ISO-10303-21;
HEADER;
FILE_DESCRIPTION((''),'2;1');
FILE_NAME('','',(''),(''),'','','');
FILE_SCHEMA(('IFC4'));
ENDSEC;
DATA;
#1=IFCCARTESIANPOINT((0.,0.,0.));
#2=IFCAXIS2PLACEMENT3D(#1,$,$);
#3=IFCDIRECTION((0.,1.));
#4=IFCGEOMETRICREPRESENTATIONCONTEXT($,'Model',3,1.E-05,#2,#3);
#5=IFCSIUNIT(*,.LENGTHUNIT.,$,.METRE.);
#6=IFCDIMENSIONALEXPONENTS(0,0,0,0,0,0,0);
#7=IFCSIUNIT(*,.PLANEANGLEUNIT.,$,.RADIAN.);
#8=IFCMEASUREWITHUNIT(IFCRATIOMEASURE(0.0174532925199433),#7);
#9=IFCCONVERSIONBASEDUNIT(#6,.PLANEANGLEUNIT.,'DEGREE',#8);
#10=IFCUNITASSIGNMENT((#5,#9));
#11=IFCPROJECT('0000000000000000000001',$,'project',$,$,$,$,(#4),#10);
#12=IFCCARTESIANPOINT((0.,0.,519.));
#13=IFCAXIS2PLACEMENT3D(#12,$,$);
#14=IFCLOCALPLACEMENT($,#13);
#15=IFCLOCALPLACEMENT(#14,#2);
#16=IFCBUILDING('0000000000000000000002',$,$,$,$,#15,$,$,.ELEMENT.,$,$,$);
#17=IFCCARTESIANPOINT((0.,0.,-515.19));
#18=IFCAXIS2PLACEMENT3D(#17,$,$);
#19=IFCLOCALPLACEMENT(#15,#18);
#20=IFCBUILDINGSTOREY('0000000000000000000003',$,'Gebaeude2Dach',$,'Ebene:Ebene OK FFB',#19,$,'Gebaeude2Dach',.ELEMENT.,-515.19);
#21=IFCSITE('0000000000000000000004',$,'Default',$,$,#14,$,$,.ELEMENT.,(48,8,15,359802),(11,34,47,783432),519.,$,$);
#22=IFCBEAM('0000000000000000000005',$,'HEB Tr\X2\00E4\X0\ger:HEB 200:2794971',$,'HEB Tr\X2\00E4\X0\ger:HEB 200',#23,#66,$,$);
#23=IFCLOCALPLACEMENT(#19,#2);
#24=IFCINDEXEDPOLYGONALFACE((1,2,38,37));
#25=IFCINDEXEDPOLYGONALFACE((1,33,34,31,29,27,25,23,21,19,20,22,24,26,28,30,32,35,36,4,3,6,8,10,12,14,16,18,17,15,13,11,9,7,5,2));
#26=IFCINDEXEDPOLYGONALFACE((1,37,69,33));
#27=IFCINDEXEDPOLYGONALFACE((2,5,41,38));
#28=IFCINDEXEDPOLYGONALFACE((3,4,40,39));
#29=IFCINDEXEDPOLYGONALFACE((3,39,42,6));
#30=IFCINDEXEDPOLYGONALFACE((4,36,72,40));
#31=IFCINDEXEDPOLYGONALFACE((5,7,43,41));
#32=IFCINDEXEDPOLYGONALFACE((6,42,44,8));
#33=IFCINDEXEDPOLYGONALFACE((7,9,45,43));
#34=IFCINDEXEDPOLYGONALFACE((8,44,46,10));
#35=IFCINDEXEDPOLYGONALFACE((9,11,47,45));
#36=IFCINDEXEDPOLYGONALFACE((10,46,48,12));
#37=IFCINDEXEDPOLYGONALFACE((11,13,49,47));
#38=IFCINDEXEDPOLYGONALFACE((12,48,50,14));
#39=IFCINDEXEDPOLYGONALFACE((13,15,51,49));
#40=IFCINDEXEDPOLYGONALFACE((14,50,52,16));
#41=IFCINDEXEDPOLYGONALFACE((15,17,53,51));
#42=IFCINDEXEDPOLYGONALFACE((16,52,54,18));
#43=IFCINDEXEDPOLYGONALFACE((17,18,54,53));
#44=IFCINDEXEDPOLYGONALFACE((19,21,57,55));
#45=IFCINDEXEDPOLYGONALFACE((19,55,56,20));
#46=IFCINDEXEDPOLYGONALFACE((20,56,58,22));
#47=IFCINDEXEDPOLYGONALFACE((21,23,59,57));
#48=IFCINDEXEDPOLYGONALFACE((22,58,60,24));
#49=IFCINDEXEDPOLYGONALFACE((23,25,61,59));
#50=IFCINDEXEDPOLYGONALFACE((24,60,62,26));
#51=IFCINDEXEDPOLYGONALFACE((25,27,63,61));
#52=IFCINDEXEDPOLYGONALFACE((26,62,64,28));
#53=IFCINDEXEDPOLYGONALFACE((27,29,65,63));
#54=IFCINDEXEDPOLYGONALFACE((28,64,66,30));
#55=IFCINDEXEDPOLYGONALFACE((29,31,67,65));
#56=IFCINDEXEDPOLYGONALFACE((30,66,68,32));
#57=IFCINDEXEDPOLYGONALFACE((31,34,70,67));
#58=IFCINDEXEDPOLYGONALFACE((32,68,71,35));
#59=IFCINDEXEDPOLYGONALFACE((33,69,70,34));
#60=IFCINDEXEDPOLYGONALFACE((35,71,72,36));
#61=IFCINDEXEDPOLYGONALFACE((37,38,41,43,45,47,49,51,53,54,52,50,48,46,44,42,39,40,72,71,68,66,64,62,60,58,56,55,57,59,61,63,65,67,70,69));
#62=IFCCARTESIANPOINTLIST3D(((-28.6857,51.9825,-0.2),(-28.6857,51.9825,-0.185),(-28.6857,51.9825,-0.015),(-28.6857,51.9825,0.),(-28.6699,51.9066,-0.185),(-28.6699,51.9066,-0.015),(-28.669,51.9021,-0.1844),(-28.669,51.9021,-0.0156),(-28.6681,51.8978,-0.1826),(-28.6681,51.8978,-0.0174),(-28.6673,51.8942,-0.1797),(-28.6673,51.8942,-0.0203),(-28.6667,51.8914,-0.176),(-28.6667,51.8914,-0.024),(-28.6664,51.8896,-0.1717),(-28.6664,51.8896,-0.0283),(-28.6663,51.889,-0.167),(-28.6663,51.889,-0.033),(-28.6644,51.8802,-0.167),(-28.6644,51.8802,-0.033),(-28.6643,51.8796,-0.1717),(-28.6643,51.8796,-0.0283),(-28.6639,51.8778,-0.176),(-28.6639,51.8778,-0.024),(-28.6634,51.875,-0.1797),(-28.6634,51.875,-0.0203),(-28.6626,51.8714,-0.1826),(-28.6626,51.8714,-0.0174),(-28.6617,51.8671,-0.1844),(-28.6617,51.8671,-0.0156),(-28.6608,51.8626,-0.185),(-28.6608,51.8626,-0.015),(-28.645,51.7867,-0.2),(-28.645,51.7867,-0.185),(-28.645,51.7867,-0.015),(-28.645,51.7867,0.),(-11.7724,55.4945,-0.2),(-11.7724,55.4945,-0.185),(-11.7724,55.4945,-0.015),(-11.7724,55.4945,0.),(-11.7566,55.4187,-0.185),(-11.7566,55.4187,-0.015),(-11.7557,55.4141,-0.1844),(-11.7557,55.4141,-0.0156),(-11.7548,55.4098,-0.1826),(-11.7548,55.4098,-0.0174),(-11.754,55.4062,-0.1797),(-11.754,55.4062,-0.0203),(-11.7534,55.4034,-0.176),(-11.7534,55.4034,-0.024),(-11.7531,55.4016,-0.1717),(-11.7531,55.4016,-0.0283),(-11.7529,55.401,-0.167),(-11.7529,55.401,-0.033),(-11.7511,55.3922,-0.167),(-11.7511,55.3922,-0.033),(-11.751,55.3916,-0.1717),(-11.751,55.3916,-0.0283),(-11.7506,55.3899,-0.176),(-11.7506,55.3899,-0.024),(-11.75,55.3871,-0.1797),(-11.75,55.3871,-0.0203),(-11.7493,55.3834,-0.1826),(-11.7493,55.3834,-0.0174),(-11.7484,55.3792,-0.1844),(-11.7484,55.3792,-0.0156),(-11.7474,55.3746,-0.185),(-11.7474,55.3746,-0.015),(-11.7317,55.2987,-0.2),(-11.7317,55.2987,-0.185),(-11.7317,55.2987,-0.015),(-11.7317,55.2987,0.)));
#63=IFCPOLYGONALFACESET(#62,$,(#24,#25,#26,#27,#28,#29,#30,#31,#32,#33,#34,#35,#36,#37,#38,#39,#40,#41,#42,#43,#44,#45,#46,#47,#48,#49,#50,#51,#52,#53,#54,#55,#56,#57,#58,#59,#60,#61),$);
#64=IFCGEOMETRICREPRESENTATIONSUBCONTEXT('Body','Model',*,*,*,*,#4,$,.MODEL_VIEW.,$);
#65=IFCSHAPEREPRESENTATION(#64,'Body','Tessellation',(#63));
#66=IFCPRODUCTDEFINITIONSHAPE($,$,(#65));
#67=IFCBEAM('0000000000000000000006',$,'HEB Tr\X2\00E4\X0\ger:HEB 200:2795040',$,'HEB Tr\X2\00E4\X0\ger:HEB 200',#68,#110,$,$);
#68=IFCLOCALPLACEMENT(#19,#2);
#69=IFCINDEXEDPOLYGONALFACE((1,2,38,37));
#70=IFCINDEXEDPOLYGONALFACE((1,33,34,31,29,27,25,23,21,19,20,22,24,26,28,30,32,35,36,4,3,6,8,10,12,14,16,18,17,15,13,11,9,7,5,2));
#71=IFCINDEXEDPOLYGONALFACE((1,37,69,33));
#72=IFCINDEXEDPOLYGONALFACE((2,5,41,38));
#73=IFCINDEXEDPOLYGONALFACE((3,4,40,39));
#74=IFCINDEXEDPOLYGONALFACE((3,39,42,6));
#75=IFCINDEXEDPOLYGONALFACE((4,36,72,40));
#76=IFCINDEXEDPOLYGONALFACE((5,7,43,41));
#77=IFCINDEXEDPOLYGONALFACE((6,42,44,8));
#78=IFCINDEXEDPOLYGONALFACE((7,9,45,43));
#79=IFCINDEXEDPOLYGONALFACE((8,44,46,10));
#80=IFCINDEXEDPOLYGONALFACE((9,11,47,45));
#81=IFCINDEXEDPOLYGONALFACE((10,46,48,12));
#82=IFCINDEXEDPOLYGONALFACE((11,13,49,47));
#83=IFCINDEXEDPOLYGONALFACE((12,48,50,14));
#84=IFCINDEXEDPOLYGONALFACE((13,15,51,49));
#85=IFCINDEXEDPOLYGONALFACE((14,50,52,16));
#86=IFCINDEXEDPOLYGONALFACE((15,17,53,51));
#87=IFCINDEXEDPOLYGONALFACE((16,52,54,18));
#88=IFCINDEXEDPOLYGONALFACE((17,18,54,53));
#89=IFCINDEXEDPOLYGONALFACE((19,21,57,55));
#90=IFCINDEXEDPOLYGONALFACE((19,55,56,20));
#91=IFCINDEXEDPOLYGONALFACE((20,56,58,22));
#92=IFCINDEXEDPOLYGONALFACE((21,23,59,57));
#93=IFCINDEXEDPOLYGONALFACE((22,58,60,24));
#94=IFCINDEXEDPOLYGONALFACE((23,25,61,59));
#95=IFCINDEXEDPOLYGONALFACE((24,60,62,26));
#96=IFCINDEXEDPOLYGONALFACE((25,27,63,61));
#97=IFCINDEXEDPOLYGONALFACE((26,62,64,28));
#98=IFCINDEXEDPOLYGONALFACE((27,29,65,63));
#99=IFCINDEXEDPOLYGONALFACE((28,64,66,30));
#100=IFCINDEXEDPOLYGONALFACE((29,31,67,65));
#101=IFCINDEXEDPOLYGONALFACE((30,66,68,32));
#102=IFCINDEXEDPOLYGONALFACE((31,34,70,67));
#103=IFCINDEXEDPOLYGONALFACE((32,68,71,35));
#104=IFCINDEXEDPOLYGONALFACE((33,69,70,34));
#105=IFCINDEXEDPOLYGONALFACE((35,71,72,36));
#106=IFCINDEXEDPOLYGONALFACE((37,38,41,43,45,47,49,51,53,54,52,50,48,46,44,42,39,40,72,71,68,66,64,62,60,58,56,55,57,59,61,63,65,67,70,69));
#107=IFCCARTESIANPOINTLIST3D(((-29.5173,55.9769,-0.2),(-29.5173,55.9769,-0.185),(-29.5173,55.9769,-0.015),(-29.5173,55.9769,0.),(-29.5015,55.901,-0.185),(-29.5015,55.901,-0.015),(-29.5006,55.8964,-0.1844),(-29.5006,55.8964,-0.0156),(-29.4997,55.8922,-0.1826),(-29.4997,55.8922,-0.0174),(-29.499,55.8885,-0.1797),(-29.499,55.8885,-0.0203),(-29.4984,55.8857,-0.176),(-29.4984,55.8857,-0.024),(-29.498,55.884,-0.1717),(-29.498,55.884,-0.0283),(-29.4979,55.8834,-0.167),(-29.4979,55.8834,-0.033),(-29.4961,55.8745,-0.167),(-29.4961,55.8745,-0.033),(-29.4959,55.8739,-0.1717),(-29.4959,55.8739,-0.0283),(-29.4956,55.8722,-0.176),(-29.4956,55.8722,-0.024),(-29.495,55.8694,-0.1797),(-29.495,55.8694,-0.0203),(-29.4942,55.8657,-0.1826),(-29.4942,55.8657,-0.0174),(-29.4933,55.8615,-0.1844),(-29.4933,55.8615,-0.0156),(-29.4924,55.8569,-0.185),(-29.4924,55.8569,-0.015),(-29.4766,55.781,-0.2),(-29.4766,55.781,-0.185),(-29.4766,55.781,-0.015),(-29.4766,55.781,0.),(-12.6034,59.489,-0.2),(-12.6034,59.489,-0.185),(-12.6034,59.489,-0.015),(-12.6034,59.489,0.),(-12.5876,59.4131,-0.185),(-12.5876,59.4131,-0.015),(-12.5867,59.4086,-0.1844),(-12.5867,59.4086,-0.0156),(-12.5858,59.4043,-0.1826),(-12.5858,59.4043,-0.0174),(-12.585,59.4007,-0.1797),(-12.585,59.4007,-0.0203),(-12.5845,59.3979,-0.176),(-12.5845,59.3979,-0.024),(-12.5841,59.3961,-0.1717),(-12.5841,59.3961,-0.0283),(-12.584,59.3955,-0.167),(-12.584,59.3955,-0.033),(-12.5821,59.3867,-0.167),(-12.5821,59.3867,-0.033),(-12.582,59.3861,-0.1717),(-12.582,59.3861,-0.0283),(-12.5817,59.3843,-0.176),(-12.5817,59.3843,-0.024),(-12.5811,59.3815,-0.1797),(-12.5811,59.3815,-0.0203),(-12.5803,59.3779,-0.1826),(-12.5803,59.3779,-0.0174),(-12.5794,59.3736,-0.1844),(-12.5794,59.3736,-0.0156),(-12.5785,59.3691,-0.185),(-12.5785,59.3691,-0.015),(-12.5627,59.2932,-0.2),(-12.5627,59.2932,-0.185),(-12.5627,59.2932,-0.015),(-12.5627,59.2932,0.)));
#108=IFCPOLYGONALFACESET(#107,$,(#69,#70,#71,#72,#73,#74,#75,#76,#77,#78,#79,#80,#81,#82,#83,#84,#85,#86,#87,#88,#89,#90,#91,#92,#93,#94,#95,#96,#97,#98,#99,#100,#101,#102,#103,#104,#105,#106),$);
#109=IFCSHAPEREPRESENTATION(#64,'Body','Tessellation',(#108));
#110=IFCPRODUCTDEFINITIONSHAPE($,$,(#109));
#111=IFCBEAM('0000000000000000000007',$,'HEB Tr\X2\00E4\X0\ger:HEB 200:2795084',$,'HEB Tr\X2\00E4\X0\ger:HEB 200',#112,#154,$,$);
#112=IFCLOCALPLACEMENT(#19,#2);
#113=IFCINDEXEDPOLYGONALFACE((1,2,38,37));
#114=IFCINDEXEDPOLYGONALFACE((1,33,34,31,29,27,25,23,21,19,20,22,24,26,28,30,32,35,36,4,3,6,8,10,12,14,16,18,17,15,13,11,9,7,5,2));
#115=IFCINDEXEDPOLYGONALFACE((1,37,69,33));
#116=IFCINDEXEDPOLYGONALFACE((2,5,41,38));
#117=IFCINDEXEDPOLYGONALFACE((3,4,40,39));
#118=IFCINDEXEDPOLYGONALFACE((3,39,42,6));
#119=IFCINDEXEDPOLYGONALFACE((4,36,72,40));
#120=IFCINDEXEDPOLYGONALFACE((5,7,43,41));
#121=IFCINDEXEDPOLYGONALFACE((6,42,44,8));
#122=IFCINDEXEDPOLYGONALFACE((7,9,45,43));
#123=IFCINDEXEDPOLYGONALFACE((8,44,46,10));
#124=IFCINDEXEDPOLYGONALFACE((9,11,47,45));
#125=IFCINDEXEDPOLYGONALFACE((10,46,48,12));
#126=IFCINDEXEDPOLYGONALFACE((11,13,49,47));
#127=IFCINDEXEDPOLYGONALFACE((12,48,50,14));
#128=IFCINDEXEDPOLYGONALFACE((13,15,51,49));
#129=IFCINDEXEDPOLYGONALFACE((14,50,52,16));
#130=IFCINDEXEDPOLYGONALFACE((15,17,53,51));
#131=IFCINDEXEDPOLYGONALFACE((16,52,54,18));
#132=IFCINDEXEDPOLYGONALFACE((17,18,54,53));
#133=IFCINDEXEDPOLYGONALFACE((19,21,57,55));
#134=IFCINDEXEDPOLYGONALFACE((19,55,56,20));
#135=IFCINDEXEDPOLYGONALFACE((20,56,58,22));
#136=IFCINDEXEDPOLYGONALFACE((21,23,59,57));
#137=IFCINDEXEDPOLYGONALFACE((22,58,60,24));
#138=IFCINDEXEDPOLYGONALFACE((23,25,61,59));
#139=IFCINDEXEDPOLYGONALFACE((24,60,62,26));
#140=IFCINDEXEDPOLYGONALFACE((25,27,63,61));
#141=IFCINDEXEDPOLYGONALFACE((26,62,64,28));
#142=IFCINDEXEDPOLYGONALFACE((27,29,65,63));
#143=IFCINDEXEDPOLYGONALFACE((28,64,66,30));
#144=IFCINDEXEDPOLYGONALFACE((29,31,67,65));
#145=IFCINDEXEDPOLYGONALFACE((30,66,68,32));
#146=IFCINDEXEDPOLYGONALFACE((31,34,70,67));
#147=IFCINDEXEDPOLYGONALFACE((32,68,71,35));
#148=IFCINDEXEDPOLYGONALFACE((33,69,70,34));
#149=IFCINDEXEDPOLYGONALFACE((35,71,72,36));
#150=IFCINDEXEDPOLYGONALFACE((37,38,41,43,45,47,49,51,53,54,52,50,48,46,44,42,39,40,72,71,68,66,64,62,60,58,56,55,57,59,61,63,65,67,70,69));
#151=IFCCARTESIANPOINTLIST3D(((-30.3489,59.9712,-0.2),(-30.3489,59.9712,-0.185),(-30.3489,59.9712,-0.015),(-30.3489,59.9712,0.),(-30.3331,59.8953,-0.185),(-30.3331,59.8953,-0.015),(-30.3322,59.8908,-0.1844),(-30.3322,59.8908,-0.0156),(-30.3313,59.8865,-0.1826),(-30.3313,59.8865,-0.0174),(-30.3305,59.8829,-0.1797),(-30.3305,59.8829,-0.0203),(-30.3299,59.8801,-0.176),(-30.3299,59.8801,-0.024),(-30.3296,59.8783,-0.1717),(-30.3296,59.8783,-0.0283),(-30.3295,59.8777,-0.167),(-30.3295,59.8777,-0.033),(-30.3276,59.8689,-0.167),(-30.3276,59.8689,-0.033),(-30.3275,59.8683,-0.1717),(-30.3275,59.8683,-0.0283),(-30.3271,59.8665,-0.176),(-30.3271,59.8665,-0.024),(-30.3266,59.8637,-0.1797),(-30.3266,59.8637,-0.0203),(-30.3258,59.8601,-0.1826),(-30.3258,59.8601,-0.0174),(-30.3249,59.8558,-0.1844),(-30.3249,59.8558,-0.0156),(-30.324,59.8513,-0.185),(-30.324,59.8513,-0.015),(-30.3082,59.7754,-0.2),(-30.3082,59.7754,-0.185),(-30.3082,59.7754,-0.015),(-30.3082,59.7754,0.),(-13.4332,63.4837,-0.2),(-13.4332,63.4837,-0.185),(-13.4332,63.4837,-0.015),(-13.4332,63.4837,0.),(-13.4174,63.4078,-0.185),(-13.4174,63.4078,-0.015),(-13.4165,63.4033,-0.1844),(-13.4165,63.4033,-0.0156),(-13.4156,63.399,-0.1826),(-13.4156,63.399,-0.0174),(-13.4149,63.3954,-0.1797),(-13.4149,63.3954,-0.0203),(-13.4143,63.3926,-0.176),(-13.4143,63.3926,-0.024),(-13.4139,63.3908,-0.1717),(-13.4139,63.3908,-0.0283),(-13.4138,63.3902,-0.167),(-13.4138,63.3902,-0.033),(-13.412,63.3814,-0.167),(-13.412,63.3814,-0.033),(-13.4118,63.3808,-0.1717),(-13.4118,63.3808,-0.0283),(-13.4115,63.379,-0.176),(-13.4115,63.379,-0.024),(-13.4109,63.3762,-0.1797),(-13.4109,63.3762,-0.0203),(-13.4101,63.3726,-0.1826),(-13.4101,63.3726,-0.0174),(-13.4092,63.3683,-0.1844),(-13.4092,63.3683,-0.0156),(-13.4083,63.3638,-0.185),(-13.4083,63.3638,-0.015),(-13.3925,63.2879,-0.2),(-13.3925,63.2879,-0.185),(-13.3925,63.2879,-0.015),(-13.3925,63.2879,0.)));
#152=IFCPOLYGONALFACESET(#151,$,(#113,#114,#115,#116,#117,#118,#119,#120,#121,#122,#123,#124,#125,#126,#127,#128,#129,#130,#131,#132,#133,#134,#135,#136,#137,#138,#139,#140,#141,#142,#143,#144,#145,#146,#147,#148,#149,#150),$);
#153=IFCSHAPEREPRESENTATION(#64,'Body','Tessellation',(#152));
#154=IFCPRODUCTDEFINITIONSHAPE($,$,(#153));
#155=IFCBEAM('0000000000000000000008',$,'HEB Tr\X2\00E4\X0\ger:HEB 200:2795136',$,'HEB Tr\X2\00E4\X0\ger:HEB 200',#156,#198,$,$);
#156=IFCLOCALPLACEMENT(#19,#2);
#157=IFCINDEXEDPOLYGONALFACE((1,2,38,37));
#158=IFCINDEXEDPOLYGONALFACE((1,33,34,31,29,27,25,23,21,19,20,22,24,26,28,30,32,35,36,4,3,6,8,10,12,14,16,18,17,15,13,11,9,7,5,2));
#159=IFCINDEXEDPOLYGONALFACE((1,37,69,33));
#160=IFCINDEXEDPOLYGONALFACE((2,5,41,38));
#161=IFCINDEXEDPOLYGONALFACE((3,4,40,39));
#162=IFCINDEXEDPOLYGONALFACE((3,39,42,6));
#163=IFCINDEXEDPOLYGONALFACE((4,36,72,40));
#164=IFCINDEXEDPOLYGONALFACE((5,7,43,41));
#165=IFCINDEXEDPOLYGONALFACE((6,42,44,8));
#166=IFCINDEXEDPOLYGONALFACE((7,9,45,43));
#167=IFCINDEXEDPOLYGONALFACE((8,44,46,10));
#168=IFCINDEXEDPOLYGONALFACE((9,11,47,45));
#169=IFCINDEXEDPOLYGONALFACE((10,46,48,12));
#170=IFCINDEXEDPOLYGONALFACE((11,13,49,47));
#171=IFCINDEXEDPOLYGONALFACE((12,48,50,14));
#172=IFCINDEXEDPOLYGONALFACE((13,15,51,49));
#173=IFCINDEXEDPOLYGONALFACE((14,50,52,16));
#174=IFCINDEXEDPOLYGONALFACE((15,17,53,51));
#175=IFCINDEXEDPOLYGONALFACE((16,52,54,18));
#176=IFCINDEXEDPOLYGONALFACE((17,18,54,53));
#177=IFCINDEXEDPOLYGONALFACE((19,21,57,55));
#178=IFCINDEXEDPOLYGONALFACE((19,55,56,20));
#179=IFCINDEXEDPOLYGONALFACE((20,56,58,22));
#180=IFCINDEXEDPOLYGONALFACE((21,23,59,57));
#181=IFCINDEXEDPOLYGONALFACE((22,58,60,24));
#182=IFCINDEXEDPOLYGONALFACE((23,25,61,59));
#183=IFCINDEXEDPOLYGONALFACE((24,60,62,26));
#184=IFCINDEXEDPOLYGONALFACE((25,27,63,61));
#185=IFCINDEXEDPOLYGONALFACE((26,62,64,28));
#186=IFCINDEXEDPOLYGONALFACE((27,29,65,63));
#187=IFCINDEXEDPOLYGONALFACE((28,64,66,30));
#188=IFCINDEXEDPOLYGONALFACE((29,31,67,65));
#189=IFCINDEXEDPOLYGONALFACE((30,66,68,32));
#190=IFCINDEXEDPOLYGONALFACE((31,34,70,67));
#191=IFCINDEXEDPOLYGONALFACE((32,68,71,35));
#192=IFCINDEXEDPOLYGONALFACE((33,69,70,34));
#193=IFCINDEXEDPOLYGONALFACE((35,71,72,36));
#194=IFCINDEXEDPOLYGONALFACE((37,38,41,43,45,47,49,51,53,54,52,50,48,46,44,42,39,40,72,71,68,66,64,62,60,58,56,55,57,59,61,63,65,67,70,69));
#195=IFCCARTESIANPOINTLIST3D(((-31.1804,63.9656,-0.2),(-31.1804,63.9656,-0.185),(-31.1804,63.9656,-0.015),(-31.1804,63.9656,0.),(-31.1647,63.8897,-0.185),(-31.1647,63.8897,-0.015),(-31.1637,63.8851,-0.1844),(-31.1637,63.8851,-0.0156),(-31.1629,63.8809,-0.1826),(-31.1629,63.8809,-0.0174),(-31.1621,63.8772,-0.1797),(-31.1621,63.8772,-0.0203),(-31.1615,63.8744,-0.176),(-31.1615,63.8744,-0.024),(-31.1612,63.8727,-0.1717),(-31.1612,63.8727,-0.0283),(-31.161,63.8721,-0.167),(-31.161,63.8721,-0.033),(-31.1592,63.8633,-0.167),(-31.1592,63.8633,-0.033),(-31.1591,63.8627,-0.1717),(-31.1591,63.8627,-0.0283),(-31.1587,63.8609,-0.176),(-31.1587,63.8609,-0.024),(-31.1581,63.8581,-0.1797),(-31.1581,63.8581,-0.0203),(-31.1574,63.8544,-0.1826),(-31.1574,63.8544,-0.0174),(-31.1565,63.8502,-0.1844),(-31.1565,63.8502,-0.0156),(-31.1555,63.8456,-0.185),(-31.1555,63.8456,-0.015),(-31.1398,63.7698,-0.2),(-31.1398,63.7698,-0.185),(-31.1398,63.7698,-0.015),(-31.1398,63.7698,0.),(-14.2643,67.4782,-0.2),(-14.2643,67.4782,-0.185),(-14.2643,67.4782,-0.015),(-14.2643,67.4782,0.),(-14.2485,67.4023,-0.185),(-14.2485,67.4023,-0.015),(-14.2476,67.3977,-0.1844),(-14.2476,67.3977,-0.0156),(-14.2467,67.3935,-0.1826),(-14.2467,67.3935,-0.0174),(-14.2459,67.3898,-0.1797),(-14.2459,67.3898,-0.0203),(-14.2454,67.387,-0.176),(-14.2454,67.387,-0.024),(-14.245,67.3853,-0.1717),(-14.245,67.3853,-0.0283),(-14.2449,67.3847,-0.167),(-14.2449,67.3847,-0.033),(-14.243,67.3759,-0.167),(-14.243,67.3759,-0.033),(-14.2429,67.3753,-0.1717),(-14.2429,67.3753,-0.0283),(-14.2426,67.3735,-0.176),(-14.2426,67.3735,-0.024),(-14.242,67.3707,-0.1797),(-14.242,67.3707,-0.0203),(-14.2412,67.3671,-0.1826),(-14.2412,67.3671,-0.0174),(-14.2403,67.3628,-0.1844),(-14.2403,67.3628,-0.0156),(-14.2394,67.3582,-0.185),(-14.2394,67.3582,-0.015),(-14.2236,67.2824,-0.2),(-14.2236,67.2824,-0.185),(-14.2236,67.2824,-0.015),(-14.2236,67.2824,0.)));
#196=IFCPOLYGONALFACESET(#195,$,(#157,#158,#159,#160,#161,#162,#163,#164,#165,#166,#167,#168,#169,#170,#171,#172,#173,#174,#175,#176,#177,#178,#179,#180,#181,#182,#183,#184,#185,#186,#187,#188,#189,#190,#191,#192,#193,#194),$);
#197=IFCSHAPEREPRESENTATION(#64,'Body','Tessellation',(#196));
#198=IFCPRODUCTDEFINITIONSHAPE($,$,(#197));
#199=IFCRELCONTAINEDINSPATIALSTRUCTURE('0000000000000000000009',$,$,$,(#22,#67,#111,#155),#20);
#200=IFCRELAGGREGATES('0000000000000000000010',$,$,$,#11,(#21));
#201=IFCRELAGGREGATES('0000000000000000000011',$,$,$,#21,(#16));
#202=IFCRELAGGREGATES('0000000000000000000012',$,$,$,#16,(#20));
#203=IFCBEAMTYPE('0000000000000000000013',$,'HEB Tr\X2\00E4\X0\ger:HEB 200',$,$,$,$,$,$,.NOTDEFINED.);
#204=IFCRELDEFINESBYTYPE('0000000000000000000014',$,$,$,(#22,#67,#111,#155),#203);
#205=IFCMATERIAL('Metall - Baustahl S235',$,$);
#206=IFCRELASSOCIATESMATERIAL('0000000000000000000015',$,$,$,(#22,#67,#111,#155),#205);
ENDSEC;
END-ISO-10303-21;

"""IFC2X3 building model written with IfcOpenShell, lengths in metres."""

from ifc_helpers import new_model, entity, si_unit, converted_unit, direction, frame, frame_2d, origin, place, context, subcontext, project, spatial, i_section, extrude, material, type_object, element, save


model = new_model("IFC2X3")

# Units and contexts
model_context = context("Model", 3, precision=1e-05, world=origin(), true_north=direction((0.0, 1.0)))
body_context = subcontext(model_context, "Body", "Model", "MODEL_VIEW")
ifc_project = project(units=[si_unit("LENGTHUNIT", "METRE"), converted_unit("PLANEANGLEUNIT", "DEGREE", entity("IfcRatioMeasure", 0.0174532925199433), si_unit("PLANEANGLEUNIT", "RADIAN"), dimensions=[0, 0, 0, 0, 0, 0, 0])], contexts=[model_context])

# Site, building, storey
site_placement = place(None, frame((0.0, 0.0, 519.0)))
site = spatial("IfcSite", under=ifc_project, at=site_placement, Name="Default", CompositionType="ELEMENT", RefLatitude=(48, 8, 15, 359802), RefLongitude=(11, 34, 47, 783432), RefElevation=519.0)
building_placement = place(site_placement, origin())
building = spatial("IfcBuilding", under=site, at=building_placement, CompositionType="ELEMENT")
storey_placement = place(building_placement, frame((0.0, 0.0, -515.19)))
storey = spatial("IfcBuildingStorey", under=building, at=storey_placement, Name="Gebaeude2Dach", ObjectType="Ebene:Ebene OK FFB", LongName="Gebaeude2Dach", CompositionType="ELEMENT", Elevation=-515.19)

# Beams
ifc_material = material(Name="Metall - Baustahl S235")
beam_type = type_object("IfcBeamType", Name="HEB Träger:HEB 200", PredefinedType="NOTDEFINED")
beam_1_placement = place(storey_placement, frame((-11.6386, 55.4202, 0.0), z_axis=(0.0, 0.0, 1.0), x_axis=(-0.979114, -0.203311, 0.0)))
element("IfcBeam", 1, at=beam_1_placement, inside=storey, type_object=beam_type, material=ifc_material, Name="HEB Träger:HEB 200:2794971", ObjectType="HEB Träger:HEB 200", context=body_context, shape_type="SweptSolid", body=[
    extrude(i_section(OverallWidth=0.2, OverallDepth=0.2, WebThickness=0.009, FlangeThickness=0.015, FilletRadius=0.018, at=frame_2d((0.0, 0.0), x_axis=(0.0, 1.0))), frame((0.1158, 0.0, -0.1), z_axis=(1.0, 0.0, 0.0), x_axis=(0.0, 0.0, -1.0)), (0.0, 0.0, 1.0), 17.2741),
])
beam_2_placement = place(storey_placement, frame((-12.4697, 59.4146, 0.0), z_axis=(0.0, 0.0, 1.0), x_axis=(-0.979114, -0.203311, 0.0)))
element("IfcBeam", 2, at=beam_2_placement, inside=storey, type_object=beam_type, material=ifc_material, Name="HEB Träger:HEB 200:2795040", ObjectType="HEB Träger:HEB 200", context=body_context, shape_type="SweptSolid", body=[
    extrude(i_section(OverallWidth=0.2, OverallDepth=0.2, WebThickness=0.009, FlangeThickness=0.015, FilletRadius=0.018, at=frame_2d((0.0, 0.0), x_axis=(0.0, 1.0))), frame((0.1158, 0.0, -0.1), z_axis=(1.0, 0.0, 0.0), x_axis=(0.0, 0.0, -1.0)), (0.0, 0.0, 1.0), 17.2747),
])
beam_3_placement = place(storey_placement, frame((-13.2995, 63.4094, 0.0), z_axis=(0.0, 0.0, 1.0), x_axis=(-0.979114, -0.203311, 0.0)))
element("IfcBeam", 3, at=beam_3_placement, inside=storey, type_object=beam_type, material=ifc_material, Name="HEB Träger:HEB 200:2795084", ObjectType="HEB Träger:HEB 200", context=body_context, shape_type="SweptSolid", body=[
    extrude(i_section(OverallWidth=0.2, OverallDepth=0.2, WebThickness=0.009, FlangeThickness=0.015, FilletRadius=0.018, at=frame_2d((0.0, 0.0), x_axis=(0.0, 1.0))), frame((0.1158, 0.0, -0.1), z_axis=(1.0, 0.0, 0.0), x_axis=(0.0, 0.0, -1.0)), (0.0, 0.0, 1.0), 17.2765),
])
beam_4_placement = place(storey_placement, frame((-14.1306, 67.4038, 0.0), z_axis=(0.0, 0.0, 1.0), x_axis=(-0.979114, -0.203311, 0.0)))
element("IfcBeam", 4, at=beam_4_placement, inside=storey, type_object=beam_type, material=ifc_material, Name="HEB Träger:HEB 200:2795136", ObjectType="HEB Träger:HEB 200", context=body_context, shape_type="SweptSolid", body=[
    extrude(i_section(OverallWidth=0.2, OverallDepth=0.2, WebThickness=0.009, FlangeThickness=0.015, FilletRadius=0.018, at=frame_2d((0.0, 0.0), x_axis=(0.0, 1.0))), frame((0.1158, 0.0, -0.1), z_axis=(1.0, 0.0, 0.0), x_axis=(0.0, 0.0, -1.0)), (0.0, 0.0, 1.0), 17.277),
])

save(model, "model.ifc")
